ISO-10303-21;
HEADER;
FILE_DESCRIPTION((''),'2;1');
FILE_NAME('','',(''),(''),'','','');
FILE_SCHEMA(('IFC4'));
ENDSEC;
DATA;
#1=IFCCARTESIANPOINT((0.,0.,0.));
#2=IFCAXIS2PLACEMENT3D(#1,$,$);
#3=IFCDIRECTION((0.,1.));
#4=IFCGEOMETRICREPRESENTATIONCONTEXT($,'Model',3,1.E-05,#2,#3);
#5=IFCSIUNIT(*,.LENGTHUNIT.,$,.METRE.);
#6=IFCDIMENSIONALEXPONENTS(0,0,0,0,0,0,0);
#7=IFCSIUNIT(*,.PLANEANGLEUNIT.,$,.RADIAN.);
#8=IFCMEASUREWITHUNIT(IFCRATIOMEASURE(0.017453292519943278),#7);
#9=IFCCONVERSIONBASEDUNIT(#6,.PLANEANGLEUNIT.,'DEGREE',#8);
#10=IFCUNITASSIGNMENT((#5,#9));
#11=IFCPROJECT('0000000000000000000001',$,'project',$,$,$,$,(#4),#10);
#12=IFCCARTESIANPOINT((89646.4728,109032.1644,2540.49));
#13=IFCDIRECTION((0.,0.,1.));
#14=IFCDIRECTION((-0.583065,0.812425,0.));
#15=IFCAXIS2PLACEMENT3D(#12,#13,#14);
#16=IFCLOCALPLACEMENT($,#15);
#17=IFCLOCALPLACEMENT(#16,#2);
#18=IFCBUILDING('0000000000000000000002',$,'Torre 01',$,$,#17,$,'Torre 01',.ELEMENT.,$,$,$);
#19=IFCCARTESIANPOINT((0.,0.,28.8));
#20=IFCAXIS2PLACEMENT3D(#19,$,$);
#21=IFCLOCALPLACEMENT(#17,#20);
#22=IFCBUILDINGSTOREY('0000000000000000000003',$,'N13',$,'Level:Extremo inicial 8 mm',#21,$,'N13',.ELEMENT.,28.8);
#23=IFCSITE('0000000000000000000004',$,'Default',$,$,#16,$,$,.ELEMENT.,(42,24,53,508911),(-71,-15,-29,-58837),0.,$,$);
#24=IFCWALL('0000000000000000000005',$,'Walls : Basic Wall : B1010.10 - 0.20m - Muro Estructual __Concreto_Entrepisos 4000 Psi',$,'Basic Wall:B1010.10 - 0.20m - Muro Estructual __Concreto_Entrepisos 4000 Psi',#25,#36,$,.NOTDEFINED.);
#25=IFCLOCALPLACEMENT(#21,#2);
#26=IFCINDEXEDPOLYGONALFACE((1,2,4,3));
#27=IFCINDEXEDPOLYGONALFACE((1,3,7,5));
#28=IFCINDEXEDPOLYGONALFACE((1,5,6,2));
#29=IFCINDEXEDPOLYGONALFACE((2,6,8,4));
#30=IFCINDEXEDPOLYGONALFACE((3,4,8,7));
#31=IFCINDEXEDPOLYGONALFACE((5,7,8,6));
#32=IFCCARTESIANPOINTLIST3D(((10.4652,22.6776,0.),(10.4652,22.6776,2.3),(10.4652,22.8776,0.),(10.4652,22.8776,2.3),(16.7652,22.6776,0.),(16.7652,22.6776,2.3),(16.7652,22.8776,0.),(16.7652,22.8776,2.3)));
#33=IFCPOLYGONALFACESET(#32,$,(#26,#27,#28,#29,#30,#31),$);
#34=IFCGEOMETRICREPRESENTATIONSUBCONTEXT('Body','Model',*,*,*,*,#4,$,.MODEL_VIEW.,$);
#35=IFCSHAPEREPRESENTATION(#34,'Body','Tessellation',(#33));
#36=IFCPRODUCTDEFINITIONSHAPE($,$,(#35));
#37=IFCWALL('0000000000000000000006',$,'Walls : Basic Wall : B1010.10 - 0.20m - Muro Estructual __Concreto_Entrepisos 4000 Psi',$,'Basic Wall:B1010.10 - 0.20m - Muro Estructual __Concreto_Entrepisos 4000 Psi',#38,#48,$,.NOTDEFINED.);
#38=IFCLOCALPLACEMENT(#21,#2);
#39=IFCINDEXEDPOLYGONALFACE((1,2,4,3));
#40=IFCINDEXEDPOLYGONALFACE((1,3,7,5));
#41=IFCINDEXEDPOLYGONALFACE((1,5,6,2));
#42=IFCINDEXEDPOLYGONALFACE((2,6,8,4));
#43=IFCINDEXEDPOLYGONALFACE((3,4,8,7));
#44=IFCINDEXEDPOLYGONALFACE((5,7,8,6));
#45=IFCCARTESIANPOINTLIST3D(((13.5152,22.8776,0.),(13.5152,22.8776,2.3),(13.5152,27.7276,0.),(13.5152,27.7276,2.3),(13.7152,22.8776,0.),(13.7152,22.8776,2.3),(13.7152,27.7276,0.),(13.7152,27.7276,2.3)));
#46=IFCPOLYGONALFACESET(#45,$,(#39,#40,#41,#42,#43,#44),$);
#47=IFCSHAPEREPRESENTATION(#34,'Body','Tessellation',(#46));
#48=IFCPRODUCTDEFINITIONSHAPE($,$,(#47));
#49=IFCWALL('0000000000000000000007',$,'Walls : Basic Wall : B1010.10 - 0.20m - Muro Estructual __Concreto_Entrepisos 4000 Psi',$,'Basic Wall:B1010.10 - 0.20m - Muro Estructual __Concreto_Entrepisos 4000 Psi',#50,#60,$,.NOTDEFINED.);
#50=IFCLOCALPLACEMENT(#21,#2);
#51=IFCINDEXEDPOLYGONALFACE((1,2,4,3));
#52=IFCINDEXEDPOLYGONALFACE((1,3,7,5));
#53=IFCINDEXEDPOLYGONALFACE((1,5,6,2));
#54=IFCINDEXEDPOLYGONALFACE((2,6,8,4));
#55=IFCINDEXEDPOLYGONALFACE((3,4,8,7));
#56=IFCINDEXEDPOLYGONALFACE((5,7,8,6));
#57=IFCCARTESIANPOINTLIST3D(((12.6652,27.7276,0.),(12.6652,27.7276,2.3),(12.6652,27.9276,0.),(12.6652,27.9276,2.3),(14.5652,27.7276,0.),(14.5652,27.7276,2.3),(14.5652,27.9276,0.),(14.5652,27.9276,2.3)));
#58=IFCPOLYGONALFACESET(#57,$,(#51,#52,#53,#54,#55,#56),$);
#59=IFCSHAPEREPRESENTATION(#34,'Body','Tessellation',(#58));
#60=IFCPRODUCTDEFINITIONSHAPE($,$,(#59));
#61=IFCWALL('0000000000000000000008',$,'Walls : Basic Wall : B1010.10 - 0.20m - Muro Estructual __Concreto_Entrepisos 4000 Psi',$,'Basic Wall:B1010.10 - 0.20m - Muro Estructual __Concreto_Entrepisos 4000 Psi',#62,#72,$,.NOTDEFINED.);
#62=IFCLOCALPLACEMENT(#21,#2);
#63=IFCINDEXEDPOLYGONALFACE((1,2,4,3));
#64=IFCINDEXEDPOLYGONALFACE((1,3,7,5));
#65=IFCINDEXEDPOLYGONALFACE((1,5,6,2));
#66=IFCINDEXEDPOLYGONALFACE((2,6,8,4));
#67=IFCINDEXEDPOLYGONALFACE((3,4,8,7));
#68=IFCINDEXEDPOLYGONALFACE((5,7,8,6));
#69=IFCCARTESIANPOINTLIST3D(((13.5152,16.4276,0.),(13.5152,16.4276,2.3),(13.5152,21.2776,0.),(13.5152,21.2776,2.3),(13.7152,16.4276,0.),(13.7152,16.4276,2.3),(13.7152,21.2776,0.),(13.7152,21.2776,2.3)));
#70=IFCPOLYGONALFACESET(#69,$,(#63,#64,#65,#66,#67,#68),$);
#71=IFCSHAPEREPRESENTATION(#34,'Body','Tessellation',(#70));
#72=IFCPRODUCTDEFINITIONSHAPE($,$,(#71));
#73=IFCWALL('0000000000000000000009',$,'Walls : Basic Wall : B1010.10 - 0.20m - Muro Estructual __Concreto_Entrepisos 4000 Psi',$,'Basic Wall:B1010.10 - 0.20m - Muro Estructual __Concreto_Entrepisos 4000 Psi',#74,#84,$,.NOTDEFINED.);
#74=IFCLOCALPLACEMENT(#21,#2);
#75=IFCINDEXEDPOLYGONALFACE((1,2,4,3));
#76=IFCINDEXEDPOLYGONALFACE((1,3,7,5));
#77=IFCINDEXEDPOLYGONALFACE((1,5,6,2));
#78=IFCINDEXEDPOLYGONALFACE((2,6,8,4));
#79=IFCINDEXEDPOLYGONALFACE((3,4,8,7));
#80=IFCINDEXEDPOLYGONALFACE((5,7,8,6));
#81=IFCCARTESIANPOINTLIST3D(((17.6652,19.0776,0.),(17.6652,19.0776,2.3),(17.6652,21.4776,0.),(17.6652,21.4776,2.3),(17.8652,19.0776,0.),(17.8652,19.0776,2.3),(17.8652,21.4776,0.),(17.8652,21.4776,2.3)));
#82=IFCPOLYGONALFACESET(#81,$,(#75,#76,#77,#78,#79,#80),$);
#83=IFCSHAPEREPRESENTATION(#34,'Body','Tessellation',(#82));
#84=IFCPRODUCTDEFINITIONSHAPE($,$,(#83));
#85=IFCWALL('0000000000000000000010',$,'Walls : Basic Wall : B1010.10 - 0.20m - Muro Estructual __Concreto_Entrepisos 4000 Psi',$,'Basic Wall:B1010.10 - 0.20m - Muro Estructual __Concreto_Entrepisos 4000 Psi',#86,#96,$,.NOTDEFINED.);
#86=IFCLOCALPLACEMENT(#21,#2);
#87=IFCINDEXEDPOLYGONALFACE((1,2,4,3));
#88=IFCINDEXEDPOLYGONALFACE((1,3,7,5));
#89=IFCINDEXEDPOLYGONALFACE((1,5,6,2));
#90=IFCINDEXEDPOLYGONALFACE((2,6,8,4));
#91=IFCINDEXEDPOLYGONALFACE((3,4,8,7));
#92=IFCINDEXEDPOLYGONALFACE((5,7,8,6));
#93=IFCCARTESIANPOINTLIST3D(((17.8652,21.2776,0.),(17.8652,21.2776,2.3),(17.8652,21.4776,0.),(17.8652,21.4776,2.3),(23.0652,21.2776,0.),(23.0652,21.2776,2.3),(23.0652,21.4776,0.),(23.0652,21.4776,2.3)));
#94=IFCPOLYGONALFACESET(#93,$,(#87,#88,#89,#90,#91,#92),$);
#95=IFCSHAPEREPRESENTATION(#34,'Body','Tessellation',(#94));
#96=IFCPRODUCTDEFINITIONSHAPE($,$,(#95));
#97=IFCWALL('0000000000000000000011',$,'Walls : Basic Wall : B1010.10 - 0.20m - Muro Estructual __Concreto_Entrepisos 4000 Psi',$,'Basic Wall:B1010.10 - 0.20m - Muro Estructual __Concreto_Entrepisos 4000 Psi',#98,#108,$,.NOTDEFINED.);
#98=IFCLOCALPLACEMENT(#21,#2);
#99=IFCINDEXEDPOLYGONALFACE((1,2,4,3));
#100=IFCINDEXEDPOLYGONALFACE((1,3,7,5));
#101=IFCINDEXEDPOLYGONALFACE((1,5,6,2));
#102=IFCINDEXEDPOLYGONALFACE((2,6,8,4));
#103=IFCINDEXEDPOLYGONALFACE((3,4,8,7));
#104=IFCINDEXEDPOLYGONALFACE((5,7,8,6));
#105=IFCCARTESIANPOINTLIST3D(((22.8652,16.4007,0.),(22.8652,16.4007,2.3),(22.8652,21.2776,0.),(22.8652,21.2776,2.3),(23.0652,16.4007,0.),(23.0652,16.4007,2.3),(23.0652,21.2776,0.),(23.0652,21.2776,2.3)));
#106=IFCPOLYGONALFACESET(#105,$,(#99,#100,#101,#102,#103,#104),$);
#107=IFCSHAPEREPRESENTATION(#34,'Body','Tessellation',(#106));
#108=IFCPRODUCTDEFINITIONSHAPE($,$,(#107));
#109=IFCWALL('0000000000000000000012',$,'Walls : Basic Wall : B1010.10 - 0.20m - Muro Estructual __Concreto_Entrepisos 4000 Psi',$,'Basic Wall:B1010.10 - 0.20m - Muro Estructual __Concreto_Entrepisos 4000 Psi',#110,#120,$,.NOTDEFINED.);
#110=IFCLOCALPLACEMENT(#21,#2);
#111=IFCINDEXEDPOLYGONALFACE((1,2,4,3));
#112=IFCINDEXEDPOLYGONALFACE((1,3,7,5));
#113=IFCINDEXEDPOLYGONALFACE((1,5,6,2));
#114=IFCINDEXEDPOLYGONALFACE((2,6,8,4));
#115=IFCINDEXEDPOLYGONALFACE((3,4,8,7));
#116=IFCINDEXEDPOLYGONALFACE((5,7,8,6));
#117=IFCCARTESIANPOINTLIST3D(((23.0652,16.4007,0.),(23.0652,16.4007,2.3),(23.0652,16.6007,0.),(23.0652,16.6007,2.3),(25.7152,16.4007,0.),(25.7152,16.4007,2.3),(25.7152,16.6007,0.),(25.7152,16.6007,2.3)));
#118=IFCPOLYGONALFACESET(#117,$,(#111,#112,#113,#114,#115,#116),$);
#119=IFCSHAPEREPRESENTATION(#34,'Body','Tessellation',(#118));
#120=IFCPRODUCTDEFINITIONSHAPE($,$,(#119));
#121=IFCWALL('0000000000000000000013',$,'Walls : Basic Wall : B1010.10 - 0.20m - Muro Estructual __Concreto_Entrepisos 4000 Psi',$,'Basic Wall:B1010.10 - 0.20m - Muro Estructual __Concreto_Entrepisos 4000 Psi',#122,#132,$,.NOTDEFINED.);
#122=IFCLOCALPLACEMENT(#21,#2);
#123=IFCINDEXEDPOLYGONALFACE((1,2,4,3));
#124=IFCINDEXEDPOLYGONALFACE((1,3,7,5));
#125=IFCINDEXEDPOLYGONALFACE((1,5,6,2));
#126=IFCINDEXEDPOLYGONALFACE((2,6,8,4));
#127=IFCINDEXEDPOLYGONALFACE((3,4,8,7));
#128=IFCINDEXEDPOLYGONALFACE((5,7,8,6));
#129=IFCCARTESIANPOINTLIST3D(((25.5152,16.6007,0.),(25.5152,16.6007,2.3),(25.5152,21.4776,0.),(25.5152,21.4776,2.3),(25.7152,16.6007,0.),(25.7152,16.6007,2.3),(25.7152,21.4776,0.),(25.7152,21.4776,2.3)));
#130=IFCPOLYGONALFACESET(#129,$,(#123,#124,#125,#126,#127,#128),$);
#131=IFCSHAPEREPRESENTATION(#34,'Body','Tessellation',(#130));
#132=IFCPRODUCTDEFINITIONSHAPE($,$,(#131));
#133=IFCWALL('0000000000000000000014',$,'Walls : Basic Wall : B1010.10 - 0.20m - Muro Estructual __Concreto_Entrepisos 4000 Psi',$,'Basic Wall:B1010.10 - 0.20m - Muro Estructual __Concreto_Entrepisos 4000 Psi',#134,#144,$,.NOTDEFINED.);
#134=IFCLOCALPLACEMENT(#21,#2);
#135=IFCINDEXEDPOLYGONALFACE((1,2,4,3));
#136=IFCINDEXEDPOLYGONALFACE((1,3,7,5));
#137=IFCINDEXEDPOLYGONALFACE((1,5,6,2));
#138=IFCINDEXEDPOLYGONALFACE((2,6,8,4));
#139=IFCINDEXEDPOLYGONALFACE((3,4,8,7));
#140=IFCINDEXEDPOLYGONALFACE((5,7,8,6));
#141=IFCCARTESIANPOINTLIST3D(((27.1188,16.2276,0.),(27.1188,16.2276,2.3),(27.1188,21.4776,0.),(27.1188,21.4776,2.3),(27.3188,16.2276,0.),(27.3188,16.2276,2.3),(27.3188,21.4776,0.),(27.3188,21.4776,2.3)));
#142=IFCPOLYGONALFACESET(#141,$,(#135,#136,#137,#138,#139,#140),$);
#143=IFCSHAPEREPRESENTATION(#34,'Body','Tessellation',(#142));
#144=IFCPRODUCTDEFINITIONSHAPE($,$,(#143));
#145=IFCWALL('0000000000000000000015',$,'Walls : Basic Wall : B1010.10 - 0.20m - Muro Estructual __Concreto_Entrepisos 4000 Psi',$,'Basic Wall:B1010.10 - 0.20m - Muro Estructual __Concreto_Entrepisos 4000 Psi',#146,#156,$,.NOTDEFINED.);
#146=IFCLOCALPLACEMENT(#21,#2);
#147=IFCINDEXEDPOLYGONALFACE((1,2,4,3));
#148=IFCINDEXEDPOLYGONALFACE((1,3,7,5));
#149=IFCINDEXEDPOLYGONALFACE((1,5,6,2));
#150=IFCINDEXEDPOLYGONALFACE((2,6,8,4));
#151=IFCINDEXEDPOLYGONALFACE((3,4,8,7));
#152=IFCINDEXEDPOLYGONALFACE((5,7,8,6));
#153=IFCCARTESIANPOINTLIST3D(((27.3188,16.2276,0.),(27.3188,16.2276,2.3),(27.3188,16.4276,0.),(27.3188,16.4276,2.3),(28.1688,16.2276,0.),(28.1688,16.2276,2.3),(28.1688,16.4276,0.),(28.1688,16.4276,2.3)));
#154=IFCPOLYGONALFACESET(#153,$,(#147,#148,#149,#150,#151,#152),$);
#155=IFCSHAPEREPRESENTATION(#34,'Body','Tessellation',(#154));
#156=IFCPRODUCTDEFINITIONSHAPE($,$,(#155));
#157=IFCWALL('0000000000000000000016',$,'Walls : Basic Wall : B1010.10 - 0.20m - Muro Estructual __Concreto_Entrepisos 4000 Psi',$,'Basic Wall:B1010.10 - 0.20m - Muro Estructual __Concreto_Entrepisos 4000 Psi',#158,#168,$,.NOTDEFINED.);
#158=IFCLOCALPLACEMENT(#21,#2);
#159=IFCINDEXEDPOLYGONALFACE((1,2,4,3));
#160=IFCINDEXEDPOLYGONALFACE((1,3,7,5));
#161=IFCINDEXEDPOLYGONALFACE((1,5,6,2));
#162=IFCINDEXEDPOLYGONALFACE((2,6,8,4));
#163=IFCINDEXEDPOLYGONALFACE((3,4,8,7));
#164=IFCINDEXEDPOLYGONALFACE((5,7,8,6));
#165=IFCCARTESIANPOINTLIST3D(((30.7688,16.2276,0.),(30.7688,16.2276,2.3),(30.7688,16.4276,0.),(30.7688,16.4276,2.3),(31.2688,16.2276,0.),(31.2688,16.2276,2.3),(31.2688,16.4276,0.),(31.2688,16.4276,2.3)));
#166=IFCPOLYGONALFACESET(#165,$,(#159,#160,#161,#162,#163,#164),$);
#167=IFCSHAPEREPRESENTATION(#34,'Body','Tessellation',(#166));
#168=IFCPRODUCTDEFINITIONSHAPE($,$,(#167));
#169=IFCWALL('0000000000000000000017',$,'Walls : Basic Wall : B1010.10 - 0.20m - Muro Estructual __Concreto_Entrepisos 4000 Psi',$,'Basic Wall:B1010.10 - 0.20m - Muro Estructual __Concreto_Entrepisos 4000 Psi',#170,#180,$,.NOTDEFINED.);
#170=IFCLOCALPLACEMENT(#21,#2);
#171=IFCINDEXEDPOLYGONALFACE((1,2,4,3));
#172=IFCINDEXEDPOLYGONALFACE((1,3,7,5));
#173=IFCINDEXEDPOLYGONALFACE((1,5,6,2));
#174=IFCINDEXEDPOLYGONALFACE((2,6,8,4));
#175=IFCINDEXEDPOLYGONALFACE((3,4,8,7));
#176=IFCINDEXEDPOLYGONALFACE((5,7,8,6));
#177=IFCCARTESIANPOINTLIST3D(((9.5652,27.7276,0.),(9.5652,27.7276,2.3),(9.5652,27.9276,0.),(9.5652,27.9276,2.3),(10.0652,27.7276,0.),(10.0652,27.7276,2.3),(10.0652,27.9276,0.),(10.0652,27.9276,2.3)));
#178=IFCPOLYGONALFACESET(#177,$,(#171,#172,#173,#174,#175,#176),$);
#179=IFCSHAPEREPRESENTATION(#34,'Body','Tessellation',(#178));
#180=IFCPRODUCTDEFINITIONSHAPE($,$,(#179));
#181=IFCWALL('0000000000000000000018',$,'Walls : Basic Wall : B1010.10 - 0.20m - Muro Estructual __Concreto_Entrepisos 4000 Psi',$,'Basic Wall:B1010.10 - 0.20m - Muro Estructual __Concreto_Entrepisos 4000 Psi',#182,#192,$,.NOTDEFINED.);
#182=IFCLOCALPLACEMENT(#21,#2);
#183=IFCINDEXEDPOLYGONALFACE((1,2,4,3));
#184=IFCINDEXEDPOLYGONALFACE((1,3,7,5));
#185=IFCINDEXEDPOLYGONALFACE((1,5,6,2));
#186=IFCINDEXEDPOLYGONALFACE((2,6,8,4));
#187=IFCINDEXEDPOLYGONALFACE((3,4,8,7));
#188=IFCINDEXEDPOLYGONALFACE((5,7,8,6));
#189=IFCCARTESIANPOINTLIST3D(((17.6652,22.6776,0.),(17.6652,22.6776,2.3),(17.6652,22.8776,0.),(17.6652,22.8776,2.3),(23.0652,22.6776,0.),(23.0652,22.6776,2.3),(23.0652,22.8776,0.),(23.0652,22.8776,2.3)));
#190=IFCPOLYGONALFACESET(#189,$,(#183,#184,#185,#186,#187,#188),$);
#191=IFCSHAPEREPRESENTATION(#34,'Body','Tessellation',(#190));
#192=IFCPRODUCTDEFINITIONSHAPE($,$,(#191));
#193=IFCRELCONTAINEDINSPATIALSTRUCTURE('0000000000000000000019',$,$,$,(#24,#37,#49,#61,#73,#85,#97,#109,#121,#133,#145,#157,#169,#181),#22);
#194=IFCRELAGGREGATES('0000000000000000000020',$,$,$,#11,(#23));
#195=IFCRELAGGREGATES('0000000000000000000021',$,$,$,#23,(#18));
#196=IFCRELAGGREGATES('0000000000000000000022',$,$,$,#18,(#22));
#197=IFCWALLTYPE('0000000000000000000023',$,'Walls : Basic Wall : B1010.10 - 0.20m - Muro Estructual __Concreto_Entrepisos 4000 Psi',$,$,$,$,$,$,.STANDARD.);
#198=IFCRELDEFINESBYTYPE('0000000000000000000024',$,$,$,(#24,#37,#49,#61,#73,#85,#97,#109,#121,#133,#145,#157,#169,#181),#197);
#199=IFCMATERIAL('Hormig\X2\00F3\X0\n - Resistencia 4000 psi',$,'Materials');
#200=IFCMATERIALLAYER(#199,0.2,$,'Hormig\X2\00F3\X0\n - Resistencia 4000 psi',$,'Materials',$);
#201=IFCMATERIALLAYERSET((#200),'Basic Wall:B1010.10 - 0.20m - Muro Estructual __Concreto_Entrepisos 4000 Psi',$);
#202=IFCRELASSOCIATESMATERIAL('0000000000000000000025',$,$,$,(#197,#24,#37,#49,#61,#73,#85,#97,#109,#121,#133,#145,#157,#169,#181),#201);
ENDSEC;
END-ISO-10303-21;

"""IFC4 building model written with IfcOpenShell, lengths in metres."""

from ifc_helpers import new_model, entity, si_unit, converted_unit, direction, frame, frame_2d, origin, place, context, subcontext, project, spatial, rectangle, extrude, material, layer, layer_set, layer_usage, type_object, element, save


model = new_model("IFC4")

# Units and contexts
model_context = context("Model", 3, precision=1e-05, world=origin(), true_north=direction((0.0, 1.0)))
body_context = subcontext(model_context, "Body", "Model", "MODEL_VIEW")
ifc_project = project(units=[si_unit("LENGTHUNIT", "METRE"), converted_unit("PLANEANGLEUNIT", "DEGREE", entity("IfcRatioMeasure", 0.017453292519943278), si_unit("PLANEANGLEUNIT", "RADIAN"), dimensions=[0, 0, 0, 0, 0, 0, 0])], contexts=[model_context])

# Site, building, storey
site_placement = place(None, frame((89646.4728, 109032.1644, 2540.49), z_axis=(0.0, 0.0, 1.0), x_axis=(-0.583065, 0.812425, 0.0)))
site = spatial("IfcSite", under=ifc_project, at=site_placement, Name="Default", CompositionType="ELEMENT", RefLatitude=(42, 24, 53, 508911), RefLongitude=(-71, -15, -29, -58837), RefElevation=0.0)
building_placement = place(site_placement, origin())
building = spatial("IfcBuilding", under=site, at=building_placement, Name="Torre 01", LongName="Torre 01", CompositionType="ELEMENT")
storey_placement = place(building_placement, frame((0.0, 0.0, 28.8)))
storey = spatial("IfcBuildingStorey", under=building, at=storey_placement, Name="N13", ObjectType="Level:Extremo inicial 8 mm", LongName="N13", CompositionType="ELEMENT", Elevation=28.8)

# Walls
ifc_material = material(Name="Hormigón - Resistencia 4000 psi", Category="Materials")
ifc_layer_1 = layer(ifc_material, 0.2, Name="Hormigón - Resistencia 4000 psi", Category="Materials")
ifc_layer_set_1 = layer_set([ifc_layer_1], Name="Basic Wall:B1010.10 - 0.20m - Muro Estructual __Concreto_Entrepisos 4000 Psi")
ifc_layer_usage_1 = layer_usage(ifc_layer_set_1, "AXIS2", "NEGATIVE", 0.1)
wall_type_1 = type_object("IfcWallType", Name="Walls : Basic Wall : B1010.10 - 0.20m - Muro Estructual __Concreto_Entrepisos 4000 Psi", PredefinedType="STANDARD", material=ifc_layer_set_1)
wall_1_placement = place(storey_placement, frame((10.4652, 22.7776, 0.0)))
element("IfcWall", 1, at=wall_1_placement, inside=storey, type_object=wall_type_1, material=ifc_layer_usage_1, Name="Walls : Basic Wall : B1010.10 - 0.20m - Muro Estructual __Concreto_Entrepisos 4000 Psi", ObjectType="Basic Wall:B1010.10 - 0.20m - Muro Estructual __Concreto_Entrepisos 4000 Psi", PredefinedType="NOTDEFINED", context=body_context, shape_type="SweptSolid", body=[
    extrude(rectangle(XDim=6.3, YDim=0.2, at=frame_2d((3.15, 0.0), x_axis=(-1.0, 0.0))), origin(), (0.0, 0.0, 1.0), 2.3),
])
ifc_layer_usage_2 = layer_usage(ifc_layer_set_1, "AXIS2", "NEGATIVE", 0.1)
wall_2_placement = place(storey_placement, frame((13.6152, 22.8776, 0.0), z_axis=(0.0, 0.0, 1.0), x_axis=(0.0, 1.0, 0.0)))
element("IfcWall", 2, at=wall_2_placement, inside=storey, type_object=wall_type_1, material=ifc_layer_usage_2, Name="Walls : Basic Wall : B1010.10 - 0.20m - Muro Estructual __Concreto_Entrepisos 4000 Psi", ObjectType="Basic Wall:B1010.10 - 0.20m - Muro Estructual __Concreto_Entrepisos 4000 Psi", PredefinedType="NOTDEFINED", context=body_context, shape_type="SweptSolid", body=[
    extrude(rectangle(XDim=4.85, YDim=0.2, at=frame_2d((2.425, 0.0), x_axis=(-1.0, 0.0))), origin(), (0.0, 0.0, 1.0), 2.3),
])
ifc_layer_usage_3 = layer_usage(ifc_layer_set_1, "AXIS2", "NEGATIVE", 0.1)
wall_3_placement = place(storey_placement, frame((12.6652, 27.8276, 0.0)))
element("IfcWall", 3, at=wall_3_placement, inside=storey, type_object=wall_type_1, material=ifc_layer_usage_3, Name="Walls : Basic Wall : B1010.10 - 0.20m - Muro Estructual __Concreto_Entrepisos 4000 Psi", ObjectType="Basic Wall:B1010.10 - 0.20m - Muro Estructual __Concreto_Entrepisos 4000 Psi", PredefinedType="NOTDEFINED", context=body_context, shape_type="SweptSolid", body=[
    extrude(rectangle(XDim=1.9, YDim=0.2, at=frame_2d((0.95, 0.0), x_axis=(-1.0, 0.0))), origin(), (0.0, 0.0, 1.0), 2.3),
])
ifc_layer_usage_4 = layer_usage(ifc_layer_set_1, "AXIS2", "NEGATIVE", 0.1)
wall_4_placement = place(storey_placement, frame((13.6152, 21.2776, 0.0), z_axis=(0.0, 0.0, 1.0), x_axis=(0.0, -1.0, 0.0)))
element("IfcWall", 4, at=wall_4_placement, inside=storey, type_object=wall_type_1, material=ifc_layer_usage_4, Name="Walls : Basic Wall : B1010.10 - 0.20m - Muro Estructual __Concreto_Entrepisos 4000 Psi", ObjectType="Basic Wall:B1010.10 - 0.20m - Muro Estructual __Concreto_Entrepisos 4000 Psi", PredefinedType="NOTDEFINED", context=body_context, shape_type="SweptSolid", body=[
    extrude(rectangle(XDim=4.85, YDim=0.2, at=frame_2d((2.425, 0.0), x_axis=(-1.0, 0.0))), origin(), (0.0, 0.0, 1.0), 2.3),
])
ifc_layer_usage_5 = layer_usage(ifc_layer_set_1, "AXIS2", "NEGATIVE", 0.1)
wall_5_placement = place(storey_placement, frame((17.7652, 19.0776, 0.0), z_axis=(0.0, 0.0, 1.0), x_axis=(0.0, 1.0, 0.0)))
element("IfcWall", 5, at=wall_5_placement, inside=storey, type_object=wall_type_1, material=ifc_layer_usage_5, Name="Walls : Basic Wall : B1010.10 - 0.20m - Muro Estructual __Concreto_Entrepisos 4000 Psi", ObjectType="Basic Wall:B1010.10 - 0.20m - Muro Estructual __Concreto_Entrepisos 4000 Psi", PredefinedType="NOTDEFINED", context=body_context, shape_type="SweptSolid", body=[
    extrude(rectangle(XDim=2.4, YDim=0.2, at=frame_2d((1.2, 0.0), x_axis=(-1.0, 0.0))), origin(), (0.0, 0.0, 1.0), 2.3),
])
ifc_layer_usage_6 = layer_usage(ifc_layer_set_1, "AXIS2", "NEGATIVE", 0.1)
wall_6_placement = place(storey_placement, frame((17.8652, 21.3776, 0.0)))
element("IfcWall", 6, at=wall_6_placement, inside=storey, type_object=wall_type_1, material=ifc_layer_usage_6, Name="Walls : Basic Wall : B1010.10 - 0.20m - Muro Estructual __Concreto_Entrepisos 4000 Psi", ObjectType="Basic Wall:B1010.10 - 0.20m - Muro Estructual __Concreto_Entrepisos 4000 Psi", PredefinedType="NOTDEFINED", context=body_context, shape_type="SweptSolid", body=[
    extrude(rectangle(XDim=5.2, YDim=0.2, at=frame_2d((2.6, 0.0), x_axis=(-1.0, 0.0))), origin(), (0.0, 0.0, 1.0), 2.3),
])
ifc_layer_usage_7 = layer_usage(ifc_layer_set_1, "AXIS2", "NEGATIVE", 0.1)
wall_7_placement = place(storey_placement, frame((22.9652, 21.2776, 0.0), z_axis=(0.0, 0.0, 1.0), x_axis=(0.0, -1.0, 0.0)))
element("IfcWall", 7, at=wall_7_placement, inside=storey, type_object=wall_type_1, material=ifc_layer_usage_7, Name="Walls : Basic Wall : B1010.10 - 0.20m - Muro Estructual __Concreto_Entrepisos 4000 Psi", ObjectType="Basic Wall:B1010.10 - 0.20m - Muro Estructual __Concreto_Entrepisos 4000 Psi", PredefinedType="NOTDEFINED", context=body_context, shape_type="SweptSolid", body=[
    extrude(rectangle(XDim=4.8769, YDim=0.2, at=frame_2d((2.4384, 0.0), x_axis=(-1.0, 0.0))), origin(), (0.0, 0.0, 1.0), 2.3),
])
ifc_layer_usage_8 = layer_usage(ifc_layer_set_1, "AXIS2", "NEGATIVE", 0.1)
wall_8_placement = place(storey_placement, frame((23.0652, 16.5007, 0.0)))
element("IfcWall", 8, at=wall_8_placement, inside=storey, type_object=wall_type_1, material=ifc_layer_usage_8, Name="Walls : Basic Wall : B1010.10 - 0.20m - Muro Estructual __Concreto_Entrepisos 4000 Psi", ObjectType="Basic Wall:B1010.10 - 0.20m - Muro Estructual __Concreto_Entrepisos 4000 Psi", PredefinedType="NOTDEFINED", context=body_context, shape_type="SweptSolid", body=[
    extrude(rectangle(XDim=2.65, YDim=0.2, at=frame_2d((1.325, 0.0), x_axis=(-1.0, 0.0))), origin(), (0.0, 0.0, 1.0), 2.3),
])
ifc_layer_usage_9 = layer_usage(ifc_layer_set_1, "AXIS2", "NEGATIVE", 0.1)
wall_9_placement = place(storey_placement, frame((25.6152, 16.6007, 0.0), z_axis=(0.0, 0.0, 1.0), x_axis=(0.0, 1.0, 0.0)))
element("IfcWall", 9, at=wall_9_placement, inside=storey, type_object=wall_type_1, material=ifc_layer_usage_9, Name="Walls : Basic Wall : B1010.10 - 0.20m - Muro Estructual __Concreto_Entrepisos 4000 Psi", ObjectType="Basic Wall:B1010.10 - 0.20m - Muro Estructual __Concreto_Entrepisos 4000 Psi", PredefinedType="NOTDEFINED", context=body_context, shape_type="SweptSolid", body=[
    extrude(rectangle(XDim=4.8769, YDim=0.2, at=frame_2d((2.4384, 0.0), x_axis=(-1.0, 0.0))), origin(), (0.0, 0.0, 1.0), 2.3),
])
ifc_layer_usage_10 = layer_usage(ifc_layer_set_1, "AXIS2", "NEGATIVE", 0.1)
wall_10_placement = place(storey_placement, frame((27.2188, 16.2276, 0.0), z_axis=(0.0, 0.0, 1.0), x_axis=(0.0, 1.0, 0.0)))
element("IfcWall", 10, at=wall_10_placement, inside=storey, type_object=wall_type_1, material=ifc_layer_usage_10, Name="Walls : Basic Wall : B1010.10 - 0.20m - Muro Estructual __Concreto_Entrepisos 4000 Psi", ObjectType="Basic Wall:B1010.10 - 0.20m - Muro Estructual __Concreto_Entrepisos 4000 Psi", PredefinedType="NOTDEFINED", context=body_context, shape_type="SweptSolid", body=[
    extrude(rectangle(XDim=5.25, YDim=0.2, at=frame_2d((2.625, 0.0), x_axis=(-1.0, 0.0))), origin(), (0.0, 0.0, 1.0), 2.3),
])
ifc_layer_usage_11 = layer_usage(ifc_layer_set_1, "AXIS2", "NEGATIVE", 0.1)
wall_11_placement = place(storey_placement, frame((27.3188, 16.3276, 0.0)))
element("IfcWall", 11, at=wall_11_placement, inside=storey, type_object=wall_type_1, material=ifc_layer_usage_11, Name="Walls : Basic Wall : B1010.10 - 0.20m - Muro Estructual __Concreto_Entrepisos 4000 Psi", ObjectType="Basic Wall:B1010.10 - 0.20m - Muro Estructual __Concreto_Entrepisos 4000 Psi", PredefinedType="NOTDEFINED", context=body_context, shape_type="SweptSolid", body=[
    extrude(rectangle(XDim=0.85, YDim=0.2, at=frame_2d((0.425, 0.0), x_axis=(-1.0, 0.0))), origin(), (0.0, 0.0, 1.0), 2.3),
])
ifc_layer_usage_12 = layer_usage(ifc_layer_set_1, "AXIS2", "NEGATIVE", 0.1)
wall_12_placement = place(storey_placement, frame((30.7688, 16.3276, 0.0)))
element("IfcWall", 12, at=wall_12_placement, inside=storey, type_object=wall_type_1, material=ifc_layer_usage_12, Name="Walls : Basic Wall : B1010.10 - 0.20m - Muro Estructual __Concreto_Entrepisos 4000 Psi", ObjectType="Basic Wall:B1010.10 - 0.20m - Muro Estructual __Concreto_Entrepisos 4000 Psi", PredefinedType="NOTDEFINED", context=body_context, shape_type="SweptSolid", body=[
    extrude(rectangle(XDim=0.5, YDim=0.2, at=frame_2d((0.25, 0.0), x_axis=(-1.0, 0.0))), origin(), (0.0, 0.0, 1.0), 2.3),
])
ifc_layer_usage_13 = layer_usage(ifc_layer_set_1, "AXIS2", "NEGATIVE", 0.1)
wall_13_placement = place(storey_placement, frame((9.5652, 27.8276, 0.0)))
element("IfcWall", 13, at=wall_13_placement, inside=storey, type_object=wall_type_1, material=ifc_layer_usage_13, Name="Walls : Basic Wall : B1010.10 - 0.20m - Muro Estructual __Concreto_Entrepisos 4000 Psi", ObjectType="Basic Wall:B1010.10 - 0.20m - Muro Estructual __Concreto_Entrepisos 4000 Psi", PredefinedType="NOTDEFINED", context=body_context, shape_type="SweptSolid", body=[
    extrude(rectangle(XDim=0.5, YDim=0.2, at=frame_2d((0.25, 0.0), x_axis=(-1.0, 0.0))), origin(), (0.0, 0.0, 1.0), 2.3),
])
ifc_layer_usage_14 = layer_usage(ifc_layer_set_1, "AXIS2", "NEGATIVE", 0.1)
wall_14_placement = place(storey_placement, frame((17.6652, 22.7776, 0.0)))
element("IfcWall", 14, at=wall_14_placement, inside=storey, type_object=wall_type_1, material=ifc_layer_usage_14, Name="Walls : Basic Wall : B1010.10 - 0.20m - Muro Estructual __Concreto_Entrepisos 4000 Psi", ObjectType="Basic Wall:B1010.10 - 0.20m - Muro Estructual __Concreto_Entrepisos 4000 Psi", PredefinedType="NOTDEFINED", context=body_context, shape_type="SweptSolid", body=[
    extrude(rectangle(XDim=5.4, YDim=0.2, at=frame_2d((2.7, 0.0), x_axis=(-1.0, 0.0))), origin(), (0.0, 0.0, 1.0), 2.3),
])

save(model, "model.ifc")
